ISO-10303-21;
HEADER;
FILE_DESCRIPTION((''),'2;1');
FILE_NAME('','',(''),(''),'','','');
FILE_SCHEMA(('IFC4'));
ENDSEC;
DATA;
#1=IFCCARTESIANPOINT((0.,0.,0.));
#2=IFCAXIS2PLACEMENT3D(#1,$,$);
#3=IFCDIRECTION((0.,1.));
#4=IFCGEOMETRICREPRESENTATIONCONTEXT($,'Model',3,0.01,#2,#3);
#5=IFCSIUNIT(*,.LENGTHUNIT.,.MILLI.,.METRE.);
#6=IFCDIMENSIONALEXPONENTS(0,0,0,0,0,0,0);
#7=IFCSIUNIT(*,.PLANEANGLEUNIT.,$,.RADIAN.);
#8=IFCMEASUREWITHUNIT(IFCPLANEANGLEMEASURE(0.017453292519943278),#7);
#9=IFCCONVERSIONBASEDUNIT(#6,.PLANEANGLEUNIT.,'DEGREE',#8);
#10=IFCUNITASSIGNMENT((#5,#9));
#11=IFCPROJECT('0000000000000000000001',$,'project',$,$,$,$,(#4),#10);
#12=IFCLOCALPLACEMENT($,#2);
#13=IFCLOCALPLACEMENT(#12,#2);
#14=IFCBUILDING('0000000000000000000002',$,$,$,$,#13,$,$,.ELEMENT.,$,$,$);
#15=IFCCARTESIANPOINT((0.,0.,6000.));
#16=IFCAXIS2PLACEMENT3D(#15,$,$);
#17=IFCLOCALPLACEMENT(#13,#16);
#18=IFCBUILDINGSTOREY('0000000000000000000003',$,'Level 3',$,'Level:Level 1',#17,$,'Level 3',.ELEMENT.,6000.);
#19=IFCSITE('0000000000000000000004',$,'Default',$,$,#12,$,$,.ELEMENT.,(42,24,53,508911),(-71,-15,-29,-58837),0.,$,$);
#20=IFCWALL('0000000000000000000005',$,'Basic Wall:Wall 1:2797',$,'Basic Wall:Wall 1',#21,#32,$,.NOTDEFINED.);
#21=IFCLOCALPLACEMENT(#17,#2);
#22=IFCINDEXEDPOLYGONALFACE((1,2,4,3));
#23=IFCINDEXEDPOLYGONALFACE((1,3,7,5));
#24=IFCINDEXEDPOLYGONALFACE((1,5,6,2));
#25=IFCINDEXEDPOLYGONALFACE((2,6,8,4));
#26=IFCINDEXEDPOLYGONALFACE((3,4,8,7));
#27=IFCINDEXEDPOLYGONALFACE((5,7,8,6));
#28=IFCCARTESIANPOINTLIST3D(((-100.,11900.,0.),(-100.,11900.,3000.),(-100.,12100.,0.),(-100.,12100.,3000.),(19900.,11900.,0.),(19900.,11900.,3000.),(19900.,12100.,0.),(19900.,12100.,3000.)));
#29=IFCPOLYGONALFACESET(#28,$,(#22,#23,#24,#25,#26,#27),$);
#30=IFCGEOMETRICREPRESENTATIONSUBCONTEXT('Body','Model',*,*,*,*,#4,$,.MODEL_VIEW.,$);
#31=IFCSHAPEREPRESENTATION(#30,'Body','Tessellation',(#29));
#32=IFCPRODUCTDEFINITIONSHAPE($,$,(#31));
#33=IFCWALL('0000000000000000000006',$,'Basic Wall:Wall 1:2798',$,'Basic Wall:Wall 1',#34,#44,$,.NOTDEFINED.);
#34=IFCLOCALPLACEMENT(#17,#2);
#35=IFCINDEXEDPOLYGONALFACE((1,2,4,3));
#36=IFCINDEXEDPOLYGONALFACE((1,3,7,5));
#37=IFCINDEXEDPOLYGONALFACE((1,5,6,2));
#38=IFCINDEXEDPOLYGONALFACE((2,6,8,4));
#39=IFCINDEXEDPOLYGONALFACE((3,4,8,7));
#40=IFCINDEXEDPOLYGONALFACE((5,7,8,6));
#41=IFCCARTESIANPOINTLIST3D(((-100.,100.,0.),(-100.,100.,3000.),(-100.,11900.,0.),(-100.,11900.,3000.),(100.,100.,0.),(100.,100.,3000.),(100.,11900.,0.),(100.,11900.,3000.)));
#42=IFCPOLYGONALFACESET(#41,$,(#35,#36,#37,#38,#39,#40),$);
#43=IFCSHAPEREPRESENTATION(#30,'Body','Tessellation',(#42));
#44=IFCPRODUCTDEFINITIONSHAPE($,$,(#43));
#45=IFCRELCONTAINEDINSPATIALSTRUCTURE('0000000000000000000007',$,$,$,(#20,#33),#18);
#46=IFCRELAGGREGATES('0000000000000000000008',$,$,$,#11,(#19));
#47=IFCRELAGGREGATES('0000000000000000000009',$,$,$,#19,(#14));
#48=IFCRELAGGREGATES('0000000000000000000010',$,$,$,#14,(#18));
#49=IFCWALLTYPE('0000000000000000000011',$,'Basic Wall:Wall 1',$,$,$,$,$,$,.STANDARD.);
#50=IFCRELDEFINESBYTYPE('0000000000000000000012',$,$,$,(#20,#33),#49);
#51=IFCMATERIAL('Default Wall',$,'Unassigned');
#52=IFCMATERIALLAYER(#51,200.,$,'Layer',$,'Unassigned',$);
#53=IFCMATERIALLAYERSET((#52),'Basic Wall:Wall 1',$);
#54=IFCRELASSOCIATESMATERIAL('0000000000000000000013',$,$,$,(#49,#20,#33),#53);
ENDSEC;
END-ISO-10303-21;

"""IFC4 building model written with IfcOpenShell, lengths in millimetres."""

from ifc_helpers import new_model, entity, si_unit, converted_unit, direction, frame, frame_2d, origin, place, context, subcontext, project, spatial, rectangle, extrude, material, layer, layer_set, layer_usage, type_object, element, save


model = new_model("IFC4")

# Units and contexts
model_context = context("Model", 3, precision=0.01, world=origin(), true_north=direction((0.0, 1.0)))
body_context = subcontext(model_context, "Body", "Model", "MODEL_VIEW")
ifc_project = project(units=[si_unit("LENGTHUNIT", "METRE", prefix="MILLI"), converted_unit("PLANEANGLEUNIT", "DEGREE", entity("IfcPlaneAngleMeasure", 0.017453292519943278), si_unit("PLANEANGLEUNIT", "RADIAN"), dimensions=[0, 0, 0, 0, 0, 0, 0])], contexts=[model_context])

# Site, building, storey
site_placement = place(None, origin())
site = spatial("IfcSite", under=ifc_project, at=site_placement, Name="Default", CompositionType="ELEMENT", RefLatitude=(42, 24, 53, 508911), RefLongitude=(-71, -15, -29, -58837), RefElevation=0.0)
building_placement = place(site_placement, origin())
building = spatial("IfcBuilding", under=site, at=building_placement, CompositionType="ELEMENT")
storey_placement = place(building_placement, frame((0.0, 0.0, 6000.0)))
storey = spatial("IfcBuildingStorey", under=building, at=storey_placement, Name="Level 3", ObjectType="Level:Level 1", LongName="Level 3", CompositionType="ELEMENT", Elevation=6000.0)

# Walls
ifc_material_1 = material(Name="Default Wall", Category="Unassigned")
ifc_layer_1 = layer(ifc_material_1, 200.0, Name="Layer", Category="Unassigned")
ifc_layer_set_1 = layer_set([ifc_layer_1], Name="Basic Wall:Wall 1")
wall_type = type_object("IfcWallType", Name="Basic Wall:Wall 1", PredefinedType="STANDARD", material=ifc_layer_set_1)
ifc_layer_usage_1 = layer_usage(ifc_layer_set_1, "AXIS2", "NEGATIVE", 100.0)
wall_1_placement = place(storey_placement, frame((19900.0, 12000.0, 0.0), z_axis=(0.0, 0.0, 1.0), x_axis=(-1.0, 0.0, 0.0)))
element("IfcWall", 1, at=wall_1_placement, inside=storey, type_object=wall_type, material=ifc_layer_usage_1, Name="Basic Wall:Wall 1:2797", ObjectType="Basic Wall:Wall 1", PredefinedType="NOTDEFINED", context=body_context, shape_type="SweptSolid", body=[
    extrude(rectangle(XDim=20000.0, YDim=200.0, at=frame_2d((10000.0, 0.0), x_axis=(-1.0, 0.0))), origin(), (0.0, 0.0, 1.0), 3000.0),
])
ifc_layer_usage_2 = layer_usage(ifc_layer_set_1, "AXIS2", "NEGATIVE", 100.0)
wall_2_placement = place(storey_placement, frame((0.0, 11900.0, 0.0), z_axis=(0.0, 0.0, 1.0), x_axis=(0.0, -1.0, 0.0)))
element("IfcWall", 2, at=wall_2_placement, inside=storey, type_object=wall_type, material=ifc_layer_usage_2, Name="Basic Wall:Wall 1:2798", ObjectType="Basic Wall:Wall 1", PredefinedType="NOTDEFINED", context=body_context, shape_type="SweptSolid", body=[
    extrude(rectangle(XDim=11800.0, YDim=200.0, at=frame_2d((5900.0, 0.0), x_axis=(-1.0, 0.0))), origin(), (0.0, 0.0, 1.0), 3000.0),
])

save(model, "model.ifc")
